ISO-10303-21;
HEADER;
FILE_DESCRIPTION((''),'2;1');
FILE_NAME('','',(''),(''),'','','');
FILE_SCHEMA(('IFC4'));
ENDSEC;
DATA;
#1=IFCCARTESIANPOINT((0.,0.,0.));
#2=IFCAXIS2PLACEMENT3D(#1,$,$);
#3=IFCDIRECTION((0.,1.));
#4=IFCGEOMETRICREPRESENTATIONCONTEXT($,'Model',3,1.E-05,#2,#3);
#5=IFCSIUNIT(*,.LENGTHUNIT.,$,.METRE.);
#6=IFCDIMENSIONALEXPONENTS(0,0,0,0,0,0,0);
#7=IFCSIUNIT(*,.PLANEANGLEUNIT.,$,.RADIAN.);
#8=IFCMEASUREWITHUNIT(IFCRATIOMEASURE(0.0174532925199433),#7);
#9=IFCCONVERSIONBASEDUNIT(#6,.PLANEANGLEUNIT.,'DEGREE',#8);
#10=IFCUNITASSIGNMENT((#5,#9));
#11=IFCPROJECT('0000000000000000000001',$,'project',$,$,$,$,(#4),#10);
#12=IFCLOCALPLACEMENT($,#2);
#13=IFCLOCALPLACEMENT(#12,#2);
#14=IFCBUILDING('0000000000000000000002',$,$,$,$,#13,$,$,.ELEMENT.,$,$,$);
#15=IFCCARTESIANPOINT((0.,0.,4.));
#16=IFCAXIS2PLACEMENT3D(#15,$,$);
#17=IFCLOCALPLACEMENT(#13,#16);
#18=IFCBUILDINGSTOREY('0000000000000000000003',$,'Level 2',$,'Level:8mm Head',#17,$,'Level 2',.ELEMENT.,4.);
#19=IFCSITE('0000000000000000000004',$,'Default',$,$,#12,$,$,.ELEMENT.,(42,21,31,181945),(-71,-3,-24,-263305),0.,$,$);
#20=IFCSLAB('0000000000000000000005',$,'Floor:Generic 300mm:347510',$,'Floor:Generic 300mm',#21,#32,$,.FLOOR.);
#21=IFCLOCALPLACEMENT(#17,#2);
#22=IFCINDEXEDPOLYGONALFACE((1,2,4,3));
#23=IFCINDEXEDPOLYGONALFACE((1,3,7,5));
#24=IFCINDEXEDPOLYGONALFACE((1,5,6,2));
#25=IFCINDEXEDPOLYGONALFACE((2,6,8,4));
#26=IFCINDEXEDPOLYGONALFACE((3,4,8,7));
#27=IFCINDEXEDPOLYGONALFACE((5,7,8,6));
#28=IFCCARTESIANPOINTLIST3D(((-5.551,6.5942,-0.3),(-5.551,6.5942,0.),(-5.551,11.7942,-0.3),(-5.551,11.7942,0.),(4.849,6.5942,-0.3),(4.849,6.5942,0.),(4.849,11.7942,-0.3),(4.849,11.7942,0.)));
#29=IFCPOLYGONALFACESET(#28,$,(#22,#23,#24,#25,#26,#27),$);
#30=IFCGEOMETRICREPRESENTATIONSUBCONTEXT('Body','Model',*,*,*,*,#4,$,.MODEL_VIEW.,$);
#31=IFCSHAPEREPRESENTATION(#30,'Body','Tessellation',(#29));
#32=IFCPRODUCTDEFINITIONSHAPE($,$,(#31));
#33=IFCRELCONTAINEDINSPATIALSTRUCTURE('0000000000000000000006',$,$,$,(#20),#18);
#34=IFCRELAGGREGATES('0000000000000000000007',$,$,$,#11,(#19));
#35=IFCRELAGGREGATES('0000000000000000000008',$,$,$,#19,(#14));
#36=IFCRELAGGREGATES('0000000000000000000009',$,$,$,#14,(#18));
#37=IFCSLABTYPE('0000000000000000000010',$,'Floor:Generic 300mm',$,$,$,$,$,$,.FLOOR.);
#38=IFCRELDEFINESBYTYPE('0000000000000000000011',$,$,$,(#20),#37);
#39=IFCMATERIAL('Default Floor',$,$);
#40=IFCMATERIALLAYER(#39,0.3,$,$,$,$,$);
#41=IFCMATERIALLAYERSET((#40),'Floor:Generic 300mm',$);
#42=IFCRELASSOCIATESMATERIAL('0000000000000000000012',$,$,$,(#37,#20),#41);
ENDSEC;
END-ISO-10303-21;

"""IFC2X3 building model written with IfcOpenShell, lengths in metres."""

from ifc_helpers import new_model, entity, si_unit, converted_unit, direction, frame, origin, origin_2d_with_axis, place, context, subcontext, project, spatial, rectangle, extrude, material, layer, layer_set, layer_usage, type_object, element, save


model = new_model("IFC2X3")

# Units and contexts
model_context = context("Model", 3, precision=1e-05, world=origin(), true_north=direction((0.0, 1.0)))
body_context = subcontext(model_context, "Body", "Model", "MODEL_VIEW")
ifc_project = project(units=[si_unit("LENGTHUNIT", "METRE"), converted_unit("PLANEANGLEUNIT", "DEGREE", entity("IfcRatioMeasure", 0.0174532925199433), si_unit("PLANEANGLEUNIT", "RADIAN"), dimensions=[0, 0, 0, 0, 0, 0, 0])], contexts=[model_context])

# Site, building, storey
site_placement = place(None, origin())
site = spatial("IfcSite", under=ifc_project, at=site_placement, Name="Default", CompositionType="ELEMENT", RefLatitude=(42, 21, 31, 181945), RefLongitude=(-71, -3, -24, -263305), RefElevation=0.0)
building_placement = place(site_placement, origin())
building = spatial("IfcBuilding", under=site, at=building_placement, CompositionType="ELEMENT")
storey_placement = place(building_placement, frame((0.0, 0.0, 4.0)))
storey = spatial("IfcBuildingStorey", under=building, at=storey_placement, Name="Level 2", ObjectType="Level:8mm Head", LongName="Level 2", CompositionType="ELEMENT", Elevation=4.0)

# Slab
ifc_material = material(Name="Default Floor")
ifc_layer = layer(ifc_material, 0.3)
ifc_layer_set = layer_set([ifc_layer], Name="Floor:Generic 300mm")
ifc_layer_usage = layer_usage(ifc_layer_set, "AXIS3", "POSITIVE", 0.0)
slab_type = type_object("IfcSlabType", Name="Floor:Generic 300mm", PredefinedType="FLOOR", material=ifc_layer_set)
slab_placement = place(storey_placement, origin())
element("IfcSlab", 1, at=slab_placement, inside=storey, type_object=slab_type, material=ifc_layer_usage, Name="Floor:Generic 300mm:347510", ObjectType="Floor:Generic 300mm", PredefinedType="FLOOR", context=body_context, shape_type="SweptSolid", body=[
    extrude(rectangle(XDim=5.2, YDim=10.4, at=origin_2d_with_axis()), frame((-0.351, 9.1942, 0.0), z_axis=(0.0, 0.0, -1.0), x_axis=(0.0, 1.0, 0.0)), (0.0, 0.0, 1.0), 0.3),
])

save(model, "model.ifc")
